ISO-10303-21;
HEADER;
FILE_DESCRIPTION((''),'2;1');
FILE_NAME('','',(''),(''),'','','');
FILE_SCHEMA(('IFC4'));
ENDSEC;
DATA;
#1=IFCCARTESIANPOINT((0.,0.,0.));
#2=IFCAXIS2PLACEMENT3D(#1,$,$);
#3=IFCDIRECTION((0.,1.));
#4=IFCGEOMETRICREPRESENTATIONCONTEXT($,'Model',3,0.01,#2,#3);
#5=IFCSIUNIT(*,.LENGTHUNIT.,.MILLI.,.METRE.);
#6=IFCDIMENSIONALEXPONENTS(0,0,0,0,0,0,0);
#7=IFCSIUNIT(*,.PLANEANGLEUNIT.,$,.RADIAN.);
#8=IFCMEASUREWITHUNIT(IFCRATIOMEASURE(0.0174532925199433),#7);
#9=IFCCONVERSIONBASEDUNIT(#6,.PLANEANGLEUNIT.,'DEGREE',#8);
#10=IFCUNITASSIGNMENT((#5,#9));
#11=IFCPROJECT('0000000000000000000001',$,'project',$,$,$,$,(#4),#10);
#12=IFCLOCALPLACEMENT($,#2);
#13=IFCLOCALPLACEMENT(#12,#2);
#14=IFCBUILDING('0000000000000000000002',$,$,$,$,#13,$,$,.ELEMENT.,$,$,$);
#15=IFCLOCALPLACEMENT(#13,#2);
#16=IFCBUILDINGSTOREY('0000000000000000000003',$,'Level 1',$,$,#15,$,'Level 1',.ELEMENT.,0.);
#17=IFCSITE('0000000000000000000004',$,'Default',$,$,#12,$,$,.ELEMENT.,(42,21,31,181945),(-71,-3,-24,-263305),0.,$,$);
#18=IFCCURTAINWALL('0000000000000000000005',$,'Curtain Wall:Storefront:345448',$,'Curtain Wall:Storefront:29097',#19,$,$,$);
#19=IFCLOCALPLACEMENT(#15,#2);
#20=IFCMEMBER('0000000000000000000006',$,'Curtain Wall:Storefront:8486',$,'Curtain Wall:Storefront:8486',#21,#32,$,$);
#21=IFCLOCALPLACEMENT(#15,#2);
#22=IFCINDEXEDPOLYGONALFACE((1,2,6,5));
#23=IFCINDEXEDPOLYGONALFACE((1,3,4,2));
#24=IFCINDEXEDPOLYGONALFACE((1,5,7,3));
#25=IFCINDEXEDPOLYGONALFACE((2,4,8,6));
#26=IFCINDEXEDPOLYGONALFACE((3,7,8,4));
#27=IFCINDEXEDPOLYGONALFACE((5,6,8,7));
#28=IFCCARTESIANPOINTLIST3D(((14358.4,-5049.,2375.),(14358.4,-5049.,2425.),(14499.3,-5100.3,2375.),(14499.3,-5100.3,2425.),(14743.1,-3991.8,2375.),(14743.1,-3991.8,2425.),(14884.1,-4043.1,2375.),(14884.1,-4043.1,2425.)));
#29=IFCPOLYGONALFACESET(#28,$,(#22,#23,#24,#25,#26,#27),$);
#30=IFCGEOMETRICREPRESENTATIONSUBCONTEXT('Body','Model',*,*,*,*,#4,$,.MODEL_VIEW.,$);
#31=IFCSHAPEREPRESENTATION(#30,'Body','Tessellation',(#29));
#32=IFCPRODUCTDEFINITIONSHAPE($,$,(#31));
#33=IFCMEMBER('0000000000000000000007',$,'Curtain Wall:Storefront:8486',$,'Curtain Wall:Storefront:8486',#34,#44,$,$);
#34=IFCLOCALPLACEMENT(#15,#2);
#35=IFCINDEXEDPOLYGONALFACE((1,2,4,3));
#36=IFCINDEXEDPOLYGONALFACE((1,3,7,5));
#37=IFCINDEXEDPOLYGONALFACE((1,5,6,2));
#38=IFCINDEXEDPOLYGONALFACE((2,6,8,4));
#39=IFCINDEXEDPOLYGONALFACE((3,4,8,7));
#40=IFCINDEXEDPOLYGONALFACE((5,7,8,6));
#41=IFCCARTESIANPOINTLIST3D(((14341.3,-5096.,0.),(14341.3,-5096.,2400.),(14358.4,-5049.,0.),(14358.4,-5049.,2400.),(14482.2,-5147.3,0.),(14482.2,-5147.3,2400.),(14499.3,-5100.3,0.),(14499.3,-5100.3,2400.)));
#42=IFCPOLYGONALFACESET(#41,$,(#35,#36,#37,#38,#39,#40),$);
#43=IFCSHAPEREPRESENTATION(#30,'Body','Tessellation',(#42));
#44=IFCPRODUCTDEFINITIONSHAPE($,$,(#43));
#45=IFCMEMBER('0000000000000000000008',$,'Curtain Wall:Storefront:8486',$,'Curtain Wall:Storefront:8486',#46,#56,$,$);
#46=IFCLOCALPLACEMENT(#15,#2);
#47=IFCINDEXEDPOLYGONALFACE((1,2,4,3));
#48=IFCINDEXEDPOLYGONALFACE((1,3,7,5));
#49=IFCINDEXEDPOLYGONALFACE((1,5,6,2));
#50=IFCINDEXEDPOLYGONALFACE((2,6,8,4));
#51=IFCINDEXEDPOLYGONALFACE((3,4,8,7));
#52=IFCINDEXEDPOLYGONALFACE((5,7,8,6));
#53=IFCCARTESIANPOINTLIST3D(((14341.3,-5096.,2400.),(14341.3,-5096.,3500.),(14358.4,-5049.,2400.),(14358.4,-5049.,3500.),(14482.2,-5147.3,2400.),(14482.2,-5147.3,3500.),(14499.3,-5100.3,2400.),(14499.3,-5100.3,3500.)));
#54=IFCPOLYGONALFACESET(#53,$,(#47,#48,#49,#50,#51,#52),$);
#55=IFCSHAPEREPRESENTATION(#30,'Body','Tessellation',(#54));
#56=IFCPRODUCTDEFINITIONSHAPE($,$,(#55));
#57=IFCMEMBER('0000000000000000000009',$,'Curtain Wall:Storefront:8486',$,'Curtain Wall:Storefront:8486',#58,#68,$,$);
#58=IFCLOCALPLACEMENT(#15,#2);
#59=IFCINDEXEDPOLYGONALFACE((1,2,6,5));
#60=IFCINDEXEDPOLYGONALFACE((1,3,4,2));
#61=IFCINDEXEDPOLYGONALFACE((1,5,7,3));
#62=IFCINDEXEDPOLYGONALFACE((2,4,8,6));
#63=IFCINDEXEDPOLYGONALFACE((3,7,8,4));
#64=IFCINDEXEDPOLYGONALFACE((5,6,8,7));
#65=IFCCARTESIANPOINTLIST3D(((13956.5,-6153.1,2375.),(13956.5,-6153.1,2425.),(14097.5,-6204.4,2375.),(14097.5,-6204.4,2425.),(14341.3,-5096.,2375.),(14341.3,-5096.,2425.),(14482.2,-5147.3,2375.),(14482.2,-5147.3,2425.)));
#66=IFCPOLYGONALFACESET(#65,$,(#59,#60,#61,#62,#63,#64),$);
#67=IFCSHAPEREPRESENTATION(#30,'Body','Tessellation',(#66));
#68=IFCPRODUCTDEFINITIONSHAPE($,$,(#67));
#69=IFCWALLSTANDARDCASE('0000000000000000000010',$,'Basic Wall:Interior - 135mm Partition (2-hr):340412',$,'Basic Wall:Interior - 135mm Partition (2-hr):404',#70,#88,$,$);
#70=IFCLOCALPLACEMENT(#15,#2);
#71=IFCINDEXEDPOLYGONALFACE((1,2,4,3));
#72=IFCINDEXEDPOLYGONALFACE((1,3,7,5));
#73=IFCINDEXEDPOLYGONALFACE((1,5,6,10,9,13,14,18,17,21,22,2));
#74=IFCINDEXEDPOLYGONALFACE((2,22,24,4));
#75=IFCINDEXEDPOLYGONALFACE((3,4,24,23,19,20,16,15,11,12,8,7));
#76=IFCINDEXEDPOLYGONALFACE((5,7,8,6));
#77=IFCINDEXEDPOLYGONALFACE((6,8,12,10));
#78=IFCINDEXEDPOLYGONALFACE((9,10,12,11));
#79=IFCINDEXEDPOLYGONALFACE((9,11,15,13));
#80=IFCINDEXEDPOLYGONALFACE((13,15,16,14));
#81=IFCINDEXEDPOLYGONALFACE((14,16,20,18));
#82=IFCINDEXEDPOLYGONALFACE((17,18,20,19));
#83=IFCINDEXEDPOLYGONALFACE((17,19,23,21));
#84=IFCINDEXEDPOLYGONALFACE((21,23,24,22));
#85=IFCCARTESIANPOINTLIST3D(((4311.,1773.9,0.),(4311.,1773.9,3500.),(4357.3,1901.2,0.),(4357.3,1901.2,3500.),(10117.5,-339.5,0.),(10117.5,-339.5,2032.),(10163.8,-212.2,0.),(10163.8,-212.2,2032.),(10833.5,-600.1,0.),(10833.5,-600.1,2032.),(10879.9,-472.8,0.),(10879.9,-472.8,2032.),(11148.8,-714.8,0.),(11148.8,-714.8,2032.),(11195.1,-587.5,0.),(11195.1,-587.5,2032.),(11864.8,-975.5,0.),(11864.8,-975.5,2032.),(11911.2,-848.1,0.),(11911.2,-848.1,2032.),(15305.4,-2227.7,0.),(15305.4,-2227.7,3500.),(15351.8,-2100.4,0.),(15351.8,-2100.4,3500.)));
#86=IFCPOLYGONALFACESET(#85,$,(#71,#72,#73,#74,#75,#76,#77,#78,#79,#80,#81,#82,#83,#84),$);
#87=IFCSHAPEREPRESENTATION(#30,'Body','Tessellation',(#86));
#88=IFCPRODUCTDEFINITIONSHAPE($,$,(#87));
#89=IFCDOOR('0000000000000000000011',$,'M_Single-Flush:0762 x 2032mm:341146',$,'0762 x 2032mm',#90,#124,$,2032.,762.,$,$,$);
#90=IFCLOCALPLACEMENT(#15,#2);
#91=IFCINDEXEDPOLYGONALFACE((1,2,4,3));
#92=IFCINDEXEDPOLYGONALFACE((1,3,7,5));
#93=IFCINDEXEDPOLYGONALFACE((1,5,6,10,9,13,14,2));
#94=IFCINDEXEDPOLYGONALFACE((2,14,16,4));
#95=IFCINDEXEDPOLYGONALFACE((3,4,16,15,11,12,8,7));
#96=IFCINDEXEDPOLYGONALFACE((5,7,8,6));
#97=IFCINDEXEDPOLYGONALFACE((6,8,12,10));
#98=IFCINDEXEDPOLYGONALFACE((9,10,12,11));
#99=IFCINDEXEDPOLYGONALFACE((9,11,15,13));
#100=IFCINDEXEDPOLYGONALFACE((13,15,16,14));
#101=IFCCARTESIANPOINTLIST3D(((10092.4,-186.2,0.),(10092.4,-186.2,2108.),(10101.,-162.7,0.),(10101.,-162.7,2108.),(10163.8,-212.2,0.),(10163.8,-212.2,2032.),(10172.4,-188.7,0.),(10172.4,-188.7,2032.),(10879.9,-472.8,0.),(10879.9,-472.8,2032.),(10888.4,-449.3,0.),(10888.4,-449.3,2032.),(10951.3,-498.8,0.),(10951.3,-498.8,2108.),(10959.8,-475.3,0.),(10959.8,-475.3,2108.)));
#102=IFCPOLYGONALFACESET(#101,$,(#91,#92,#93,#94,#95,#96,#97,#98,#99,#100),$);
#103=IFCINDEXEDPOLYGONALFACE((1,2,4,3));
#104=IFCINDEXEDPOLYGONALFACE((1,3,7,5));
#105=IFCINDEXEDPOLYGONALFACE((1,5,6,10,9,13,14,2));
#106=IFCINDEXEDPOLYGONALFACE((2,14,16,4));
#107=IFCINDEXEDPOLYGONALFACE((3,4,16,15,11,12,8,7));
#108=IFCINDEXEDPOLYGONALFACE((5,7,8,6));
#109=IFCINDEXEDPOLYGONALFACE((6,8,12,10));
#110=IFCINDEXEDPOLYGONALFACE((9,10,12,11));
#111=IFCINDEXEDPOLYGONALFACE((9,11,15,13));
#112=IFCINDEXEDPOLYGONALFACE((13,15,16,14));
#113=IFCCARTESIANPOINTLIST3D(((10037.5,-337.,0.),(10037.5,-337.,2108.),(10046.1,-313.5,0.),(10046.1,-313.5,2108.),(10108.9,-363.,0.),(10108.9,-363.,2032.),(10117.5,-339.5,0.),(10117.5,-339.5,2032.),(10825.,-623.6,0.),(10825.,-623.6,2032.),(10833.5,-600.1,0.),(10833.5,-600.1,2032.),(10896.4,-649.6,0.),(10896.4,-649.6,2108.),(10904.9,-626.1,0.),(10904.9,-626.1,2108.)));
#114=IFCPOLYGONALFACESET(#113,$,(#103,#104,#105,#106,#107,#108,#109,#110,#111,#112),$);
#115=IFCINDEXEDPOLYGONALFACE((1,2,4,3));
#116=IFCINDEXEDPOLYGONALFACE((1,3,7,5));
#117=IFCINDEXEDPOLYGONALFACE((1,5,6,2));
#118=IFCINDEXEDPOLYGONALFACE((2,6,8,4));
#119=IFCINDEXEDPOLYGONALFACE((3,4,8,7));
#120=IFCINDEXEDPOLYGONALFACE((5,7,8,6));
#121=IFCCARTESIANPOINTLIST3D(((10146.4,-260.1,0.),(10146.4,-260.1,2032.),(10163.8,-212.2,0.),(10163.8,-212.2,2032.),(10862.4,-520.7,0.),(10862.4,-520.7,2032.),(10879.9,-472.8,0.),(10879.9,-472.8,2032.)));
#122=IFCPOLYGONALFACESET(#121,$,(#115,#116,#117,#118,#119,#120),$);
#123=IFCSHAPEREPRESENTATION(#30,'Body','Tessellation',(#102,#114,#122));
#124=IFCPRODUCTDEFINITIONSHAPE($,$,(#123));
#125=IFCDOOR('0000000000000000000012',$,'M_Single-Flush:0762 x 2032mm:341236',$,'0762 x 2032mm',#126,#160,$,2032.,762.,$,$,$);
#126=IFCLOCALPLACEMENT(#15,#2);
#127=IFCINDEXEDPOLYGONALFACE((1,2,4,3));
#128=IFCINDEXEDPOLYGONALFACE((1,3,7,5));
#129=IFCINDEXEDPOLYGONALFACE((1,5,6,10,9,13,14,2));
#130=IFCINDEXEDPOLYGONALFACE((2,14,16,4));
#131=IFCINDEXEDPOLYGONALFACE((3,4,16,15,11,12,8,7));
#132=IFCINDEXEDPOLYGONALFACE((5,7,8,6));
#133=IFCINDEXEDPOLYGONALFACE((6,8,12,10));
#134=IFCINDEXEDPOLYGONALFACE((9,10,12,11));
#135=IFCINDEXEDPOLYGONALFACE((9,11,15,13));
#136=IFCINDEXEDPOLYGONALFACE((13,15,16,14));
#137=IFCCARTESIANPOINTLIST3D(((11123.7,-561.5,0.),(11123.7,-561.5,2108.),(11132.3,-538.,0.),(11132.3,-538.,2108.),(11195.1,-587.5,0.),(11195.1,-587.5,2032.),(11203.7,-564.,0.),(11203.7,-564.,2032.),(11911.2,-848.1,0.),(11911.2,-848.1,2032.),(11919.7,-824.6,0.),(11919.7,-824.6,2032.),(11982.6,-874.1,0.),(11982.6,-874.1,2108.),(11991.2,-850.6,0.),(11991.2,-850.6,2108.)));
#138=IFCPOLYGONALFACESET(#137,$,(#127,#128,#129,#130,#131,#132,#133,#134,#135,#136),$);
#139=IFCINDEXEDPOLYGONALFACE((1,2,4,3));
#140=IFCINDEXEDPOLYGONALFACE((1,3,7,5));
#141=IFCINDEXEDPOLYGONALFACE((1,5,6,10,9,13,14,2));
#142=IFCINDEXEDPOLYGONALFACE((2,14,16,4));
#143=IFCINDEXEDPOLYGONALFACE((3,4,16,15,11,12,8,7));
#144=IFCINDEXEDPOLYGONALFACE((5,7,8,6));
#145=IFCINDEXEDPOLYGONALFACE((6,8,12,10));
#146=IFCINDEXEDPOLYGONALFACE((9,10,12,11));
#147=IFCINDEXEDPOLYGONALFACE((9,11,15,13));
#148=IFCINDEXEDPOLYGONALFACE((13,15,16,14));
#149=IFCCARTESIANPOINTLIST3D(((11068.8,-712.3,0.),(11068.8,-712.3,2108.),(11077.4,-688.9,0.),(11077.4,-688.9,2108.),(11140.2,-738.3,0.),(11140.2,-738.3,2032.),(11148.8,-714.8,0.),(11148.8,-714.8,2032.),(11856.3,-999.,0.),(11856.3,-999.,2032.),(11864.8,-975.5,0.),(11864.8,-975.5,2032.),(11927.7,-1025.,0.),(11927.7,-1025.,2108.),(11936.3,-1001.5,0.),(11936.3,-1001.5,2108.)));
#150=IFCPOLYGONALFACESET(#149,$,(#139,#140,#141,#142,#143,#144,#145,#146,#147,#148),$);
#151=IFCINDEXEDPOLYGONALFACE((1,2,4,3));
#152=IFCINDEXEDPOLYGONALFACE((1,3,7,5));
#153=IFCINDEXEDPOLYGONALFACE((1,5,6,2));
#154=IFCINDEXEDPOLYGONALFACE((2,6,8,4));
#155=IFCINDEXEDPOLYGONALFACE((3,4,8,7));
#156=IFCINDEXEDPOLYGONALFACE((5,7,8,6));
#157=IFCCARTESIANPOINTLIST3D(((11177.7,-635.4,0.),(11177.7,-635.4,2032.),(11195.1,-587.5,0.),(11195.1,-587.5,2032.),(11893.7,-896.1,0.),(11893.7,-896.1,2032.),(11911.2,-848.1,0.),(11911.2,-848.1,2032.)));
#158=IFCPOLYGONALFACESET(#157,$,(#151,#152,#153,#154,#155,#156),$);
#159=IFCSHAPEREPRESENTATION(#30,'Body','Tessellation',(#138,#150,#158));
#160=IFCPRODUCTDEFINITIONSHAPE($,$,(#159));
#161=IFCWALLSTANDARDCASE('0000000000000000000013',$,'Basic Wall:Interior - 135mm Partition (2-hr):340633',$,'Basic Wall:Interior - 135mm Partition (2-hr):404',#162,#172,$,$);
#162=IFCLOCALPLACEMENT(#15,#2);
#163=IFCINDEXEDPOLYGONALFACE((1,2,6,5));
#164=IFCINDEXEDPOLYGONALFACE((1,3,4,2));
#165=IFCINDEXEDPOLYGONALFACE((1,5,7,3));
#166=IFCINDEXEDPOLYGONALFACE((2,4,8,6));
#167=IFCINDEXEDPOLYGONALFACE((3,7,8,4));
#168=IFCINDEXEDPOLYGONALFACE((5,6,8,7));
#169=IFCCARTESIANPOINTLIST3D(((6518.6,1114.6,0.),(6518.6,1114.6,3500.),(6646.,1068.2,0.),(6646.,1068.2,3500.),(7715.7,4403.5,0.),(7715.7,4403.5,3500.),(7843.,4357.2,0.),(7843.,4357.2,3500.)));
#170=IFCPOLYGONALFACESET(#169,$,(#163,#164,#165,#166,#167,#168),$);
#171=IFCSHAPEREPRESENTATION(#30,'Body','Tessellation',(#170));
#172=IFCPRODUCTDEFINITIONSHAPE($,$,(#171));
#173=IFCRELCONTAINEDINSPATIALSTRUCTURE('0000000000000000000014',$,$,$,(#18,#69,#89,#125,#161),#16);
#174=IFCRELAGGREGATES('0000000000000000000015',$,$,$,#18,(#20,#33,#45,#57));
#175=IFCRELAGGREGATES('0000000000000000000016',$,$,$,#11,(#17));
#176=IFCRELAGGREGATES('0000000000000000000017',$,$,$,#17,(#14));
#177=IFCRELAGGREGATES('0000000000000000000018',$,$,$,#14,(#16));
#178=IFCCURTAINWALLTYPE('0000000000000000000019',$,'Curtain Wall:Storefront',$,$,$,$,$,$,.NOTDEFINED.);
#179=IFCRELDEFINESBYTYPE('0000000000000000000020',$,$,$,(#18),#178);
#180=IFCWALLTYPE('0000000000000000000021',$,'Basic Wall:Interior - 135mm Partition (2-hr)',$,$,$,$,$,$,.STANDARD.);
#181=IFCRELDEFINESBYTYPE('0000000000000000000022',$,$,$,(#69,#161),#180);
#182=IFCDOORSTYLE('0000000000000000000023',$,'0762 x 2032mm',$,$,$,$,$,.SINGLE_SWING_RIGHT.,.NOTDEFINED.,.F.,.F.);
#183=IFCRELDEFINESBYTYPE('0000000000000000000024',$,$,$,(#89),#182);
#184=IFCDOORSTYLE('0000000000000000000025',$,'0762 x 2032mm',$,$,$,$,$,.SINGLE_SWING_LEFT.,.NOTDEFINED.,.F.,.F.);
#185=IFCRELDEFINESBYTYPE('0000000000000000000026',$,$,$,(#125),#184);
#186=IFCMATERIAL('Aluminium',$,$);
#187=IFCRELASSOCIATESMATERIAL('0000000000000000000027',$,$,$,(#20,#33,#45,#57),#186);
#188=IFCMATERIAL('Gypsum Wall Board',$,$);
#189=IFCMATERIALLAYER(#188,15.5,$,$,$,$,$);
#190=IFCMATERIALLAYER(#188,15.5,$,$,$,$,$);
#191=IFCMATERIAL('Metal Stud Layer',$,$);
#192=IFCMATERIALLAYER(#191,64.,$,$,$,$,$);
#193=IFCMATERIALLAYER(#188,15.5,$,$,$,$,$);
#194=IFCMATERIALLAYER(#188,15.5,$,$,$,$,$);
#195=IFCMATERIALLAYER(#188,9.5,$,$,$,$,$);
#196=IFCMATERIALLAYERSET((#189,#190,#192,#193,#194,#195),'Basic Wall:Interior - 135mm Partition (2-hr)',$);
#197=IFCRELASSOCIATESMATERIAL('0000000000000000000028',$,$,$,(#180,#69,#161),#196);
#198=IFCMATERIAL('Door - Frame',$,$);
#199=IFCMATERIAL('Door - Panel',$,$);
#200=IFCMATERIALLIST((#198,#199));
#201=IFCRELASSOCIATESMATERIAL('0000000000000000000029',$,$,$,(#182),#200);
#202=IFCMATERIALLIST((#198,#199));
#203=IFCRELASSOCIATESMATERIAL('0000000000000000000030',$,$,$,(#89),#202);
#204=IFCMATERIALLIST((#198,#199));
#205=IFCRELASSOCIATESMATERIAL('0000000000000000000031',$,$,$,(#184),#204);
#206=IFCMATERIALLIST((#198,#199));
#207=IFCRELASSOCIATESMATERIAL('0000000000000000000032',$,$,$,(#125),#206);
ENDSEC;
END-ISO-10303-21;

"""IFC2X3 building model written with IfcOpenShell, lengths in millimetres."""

from ifc_helpers import new_model, entity, si_unit, converted_unit, direction, frame, frame_2d, origin, origin_2d_with_axis, place, context, subcontext, project, spatial, polyline, rectangle, outline, extrude, source, transform, mapped, material, material_list, layer, layer_set, layer_usage, type_object, type_shapes, element, fill, aggregate, save


model = new_model("IFC2X3")

# Units and contexts
model_context = context("Model", 3, precision=0.01, world=origin(), true_north=direction((0.0, 1.0)))
body_context = subcontext(model_context, "Body", "Model", "MODEL_VIEW")
ifc_project = project(units=[si_unit("LENGTHUNIT", "METRE", prefix="MILLI"), converted_unit("PLANEANGLEUNIT", "DEGREE", entity("IfcRatioMeasure", 0.0174532925199433), si_unit("PLANEANGLEUNIT", "RADIAN"), dimensions=[0, 0, 0, 0, 0, 0, 0])], contexts=[model_context])

# Site, building, storey
site_placement = place(None, origin())
site = spatial("IfcSite", under=ifc_project, at=site_placement, Name="Default", CompositionType="ELEMENT", RefLatitude=(42, 21, 31, 181945), RefLongitude=(-71, -3, -24, -263305), RefElevation=0.0)
building_placement = place(site_placement, origin())
building = spatial("IfcBuilding", under=site, at=building_placement, CompositionType="ELEMENT")
storey_placement = place(building_placement, origin())
storey = spatial("IfcBuildingStorey", under=building, at=storey_placement, Name="Level 1", LongName="Level 1", CompositionType="ELEMENT", Elevation=0.0)

# Curtain wall, members
curtain_wall_type = type_object("IfcCurtainWallType", Name="Curtain Wall:Storefront", PredefinedType="NOTDEFINED")
curtain_wall_placement = place(storey_placement, origin())
curtain_wall = element("IfcCurtainWall", 1, at=curtain_wall_placement, inside=storey, type_object=curtain_wall_type, Name="Curtain Wall:Storefront:345448", ObjectType="Curtain Wall:Storefront:29097")
ifc_material_1 = material(Name="Aluminium")
member_1_placement = place(curtain_wall_placement, origin())
member_1 = element("IfcMember", 2, at=member_1_placement, material=ifc_material_1, Name="Curtain Wall:Storefront:8486", ObjectType="Curtain Wall:Storefront:8486", context=body_context, shape_type="SweptSolid", body=[
    extrude(rectangle(XDim=50.0, YDim=150.0, at=origin_2d_with_axis()), frame((14813.6, -4017.5, 2400.0), z_axis=(-0.34202, -0.939693, 0.0), x_axis=(0.0, 0.0, -1.0)), (0.0, 0.0, 1.0), 1125.0),
])
member_2_placement = place(curtain_wall_placement, origin())
member_2 = element("IfcMember", 3, at=member_2_placement, material=ifc_material_1, Name="Curtain Wall:Storefront:8486", ObjectType="Curtain Wall:Storefront:8486", context=body_context, shape_type="SweptSolid", body=[
    extrude(rectangle(XDim=50.0, YDim=150.0, at=origin_2d_with_axis()), frame((14420.3, -5098.1, 0.0), z_axis=(0.0, 0.0, 1.0), x_axis=(0.34202, 0.939693, 0.0)), (0.0, 0.0, 1.0), 2400.0),
])
member_3_placement = place(curtain_wall_placement, origin())
member_3 = element("IfcMember", 4, at=member_3_placement, material=ifc_material_1, Name="Curtain Wall:Storefront:8486", ObjectType="Curtain Wall:Storefront:8486", context=body_context, shape_type="SweptSolid", body=[
    extrude(rectangle(XDim=50.0, YDim=150.0, at=origin_2d_with_axis()), frame((14420.3, -5098.1, 2400.0), z_axis=(0.0, 0.0, 1.0), x_axis=(0.34202, 0.939693, 0.0)), (0.0, 0.0, 1.0), 1100.0),
])
member_4_placement = place(curtain_wall_placement, origin())
member_4 = element("IfcMember", 5, at=member_4_placement, material=ifc_material_1, Name="Curtain Wall:Storefront:8486", ObjectType="Curtain Wall:Storefront:8486", context=body_context, shape_type="SweptSolid", body=[
    extrude(rectangle(XDim=50.0, YDim=150.0, at=frame_2d((0.0, 0.0), x_axis=(1.0, 0.0))), frame((14411.8, -5121.6, 2400.0), z_axis=(-0.34202, -0.939693, 0.0), x_axis=(0.0, 0.0, -1.0)), (0.0, 0.0, 1.0), 1125.0),
])
aggregate(curtain_wall, [member_1, member_2, member_3, member_4])

# Wall, openings, doors
ifc_material_2 = material(Name="Gypsum Wall Board")
ifc_layer_1 = layer(ifc_material_2, 15.5)
ifc_layer_2 = layer(ifc_material_2, 15.5)
ifc_material_3 = material(Name="Metal Stud Layer")
ifc_layer_3 = layer(ifc_material_3, 64.0)
ifc_layer_4 = layer(ifc_material_2, 15.5)
ifc_layer_5 = layer(ifc_material_2, 15.5)
ifc_layer_6 = layer(ifc_material_2, 9.5)
ifc_layer_set_1 = layer_set([ifc_layer_1, ifc_layer_2, ifc_layer_3, ifc_layer_4, ifc_layer_5, ifc_layer_6], Name="Basic Wall:Interior - 135mm Partition (2-hr)")
ifc_layer_usage_1 = layer_usage(ifc_layer_set_1, "AXIS2", "NEGATIVE", 67.8)
wall_type_1 = type_object("IfcWallType", Name="Basic Wall:Interior - 135mm Partition (2-hr)", PredefinedType="STANDARD", material=ifc_layer_set_1)
wall_1_placement = place(storey_placement, frame((4334.2, 1837.6, 0.0), z_axis=(0.0, 0.0, 1.0), x_axis=(0.939693, -0.34202, 0.0)))
wall_1 = element("IfcWallStandardCase", 6, at=wall_1_placement, inside=storey, type_object=wall_type_1, material=ifc_layer_usage_1, Name="Basic Wall:Interior - 135mm Partition (2-hr):340412", ObjectType="Basic Wall:Interior - 135mm Partition (2-hr):404", context=body_context, shape_type="SweptSolid", body=[
    extrude(rectangle(XDim=11700.0, YDim=135.5, at=frame_2d((5850.0, 0.0), x_axis=(-1.0, 0.0))), origin(), (0.0, 0.0, 1.0), 3500.0),
])
opening_1_placement = place(wall_1_placement, frame((6179.1, -67.8, 0.0)))
opening_1 = element("IfcOpeningElement", 7, at=opening_1_placement, cuts=wall_1, ObjectType="Opening", context=body_context, shape_type="SweptSolid", body=[
    extrude(rectangle(XDim=762.0, YDim=2032.0, at=frame_2d((1016.0, 381.0), x_axis=(0.0, 1.0))), frame((0.0, 0.0, 0.0), z_axis=(0.0, 1.0, 0.0), x_axis=(0.0, 0.0, 1.0)), (0.0, 0.0, 1.0), 135.5),
])
opening_2_placement = place(wall_1_placement, frame((7276.6, -67.8, 0.0)))
opening_2 = element("IfcOpeningElement", 8, at=opening_2_placement, cuts=wall_1, ObjectType="Opening", context=body_context, shape_type="SweptSolid", body=[
    extrude(rectangle(XDim=762.0, YDim=2032.0, at=frame_2d((1016.0, 381.0), x_axis=(0.0, -1.0))), frame((0.0, 0.0, 0.0), z_axis=(0.0, 1.0, 0.0), x_axis=(0.0, 0.0, 1.0)), (0.0, 0.0, 1.0), 135.5),
])
ifc_material_4 = material(Name="Door - Frame")
ifc_material_5 = material(Name="Door - Panel")
ifc_material_list_1 = material_list([ifc_material_4, ifc_material_5])
ifc_material_list_2 = material_list([ifc_material_4, ifc_material_5])
door_style_1 = type_object("IfcDoorStyle", Name="0762 x 2032mm", ConstructionType="NOTDEFINED", OperationType="SINGLE_SWING_RIGHT", ParameterTakesPrecedence=False, Sizeable=False, material=ifc_material_list_2)
shared_shape_1 = source(origin(), body_context, "Body", "SweptSolid", [
    extrude(outline(polyline([(-457.0, -1073.0), (457.0, -1073.0), (457.0, 1035.0), (381.0, 1035.0), (381.0, -997.0), (-381.0, -997.0), (-381.0, 1035.0), (-457.0, 1035.0), (-457.0, -1073.0)])), frame((381.0, 135.5, 1035.0), z_axis=(0.0, 1.0, 0.0), x_axis=(1.0, 0.0, 0.0)), (0.0, 0.0, 1.0), 25.0),
    extrude(outline(polyline([(-1073.0, -457.0), (1035.0, -457.0), (1035.0, -381.0), (-997.0, -381.0), (-997.0, 381.0), (1035.0, 381.0), (1035.0, 457.0), (-1073.0, 457.0), (-1073.0, -457.0)])), frame((381.0, -25.0, 1035.0), z_axis=(0.0, 1.0, 0.0), x_axis=(0.0, 0.0, -1.0)), (0.0, 0.0, 1.0), 25.0),
    extrude(rectangle(XDim=51.0, YDim=762.0, at=frame_2d((0.0, 0.0), x_axis=(1.0, 0.0))), frame((381.0, 110.0, 0.0), z_axis=(0.0, 0.0, 1.0), x_axis=(0.0, 1.0, 0.0)), (0.0, 0.0, 1.0), 2032.0),
])
type_shapes(door_style_1, [shared_shape_1])
door_1_placement = place(opening_1_placement, origin())
door_1 = element("IfcDoor", 9, at=door_1_placement, inside=storey, type_object=door_style_1, material=ifc_material_list_1, Name="M_Single-Flush:0762 x 2032mm:341146", ObjectType="0762 x 2032mm", OverallHeight=2032.0, OverallWidth=762.0, context=body_context, shape_type="MappedRepresentation", body=[
    mapped(shared_shape_1, transform((0.0, 0.0, 0.0), scale=1.0)),
])
fill(opening_1, door_1)
ifc_material_list_3 = material_list([ifc_material_4, ifc_material_5])
ifc_material_list_4 = material_list([ifc_material_4, ifc_material_5])
door_style_2 = type_object("IfcDoorStyle", Name="0762 x 2032mm", ConstructionType="NOTDEFINED", OperationType="SINGLE_SWING_LEFT", ParameterTakesPrecedence=False, Sizeable=False, material=ifc_material_list_4)
shared_shape_2 = source(origin(), body_context, "Body", "SweptSolid", [
    extrude(outline(polyline([(-457.0, -1073.0), (457.0, -1073.0), (457.0, 1035.0), (381.0, 1035.0), (381.0, -997.0), (-381.0, -997.0), (-381.0, 1035.0), (-457.0, 1035.0), (-457.0, -1073.0)])), frame((381.0, 160.5, 1035.0), z_axis=(0.0, -1.0, 0.0), x_axis=(-1.0, 0.0, 0.0)), (0.0, 0.0, 1.0), 25.0),
    extrude(outline(polyline([(-1073.0, -457.0), (1035.0, -457.0), (1035.0, -381.0), (-997.0, -381.0), (-997.0, 381.0), (1035.0, 381.0), (1035.0, 457.0), (-1073.0, 457.0), (-1073.0, -457.0)])), frame((381.0, 0.0, 1035.0), z_axis=(0.0, -1.0, 0.0), x_axis=(0.0, 0.0, -1.0)), (0.0, 0.0, 1.0), 25.0),
    extrude(rectangle(XDim=762.0, YDim=51.0, at=frame_2d((0.0, 0.0), x_axis=(1.0, 0.0))), frame((381.0, 110.0, 0.0)), (0.0, 0.0, 1.0), 2032.0),
])
type_shapes(door_style_2, [shared_shape_2])
door_2_placement = place(opening_2_placement, origin())
door_2 = element("IfcDoor", 10, at=door_2_placement, inside=storey, type_object=door_style_2, material=ifc_material_list_3, Name="M_Single-Flush:0762 x 2032mm:341236", ObjectType="0762 x 2032mm", OverallHeight=2032.0, OverallWidth=762.0, context=body_context, shape_type="MappedRepresentation", body=[
    mapped(shared_shape_2, transform((0.0, 0.0, 0.0), scale=1.0)),
])
fill(opening_2, door_2)

# Wall
ifc_layer_usage_2 = layer_usage(ifc_layer_set_1, "AXIS2", "NEGATIVE", 67.8)
wall_2_placement = place(storey_placement, frame((6582.3, 1091.4, 0.0), z_axis=(0.0, 0.0, 1.0), x_axis=(0.34202, 0.939693, 0.0)))
element("IfcWallStandardCase", 11, at=wall_2_placement, inside=storey, type_object=wall_type_1, material=ifc_layer_usage_2, Name="Basic Wall:Interior - 135mm Partition (2-hr):340633", ObjectType="Basic Wall:Interior - 135mm Partition (2-hr):404", context=body_context, shape_type="SweptSolid", body=[
    extrude(rectangle(XDim=3500.0, YDim=135.5, at=frame_2d((1750.0, 0.0), x_axis=(-1.0, 0.0))), origin(), (0.0, 0.0, 1.0), 3500.0),
])

save(model, "model.ifc")
